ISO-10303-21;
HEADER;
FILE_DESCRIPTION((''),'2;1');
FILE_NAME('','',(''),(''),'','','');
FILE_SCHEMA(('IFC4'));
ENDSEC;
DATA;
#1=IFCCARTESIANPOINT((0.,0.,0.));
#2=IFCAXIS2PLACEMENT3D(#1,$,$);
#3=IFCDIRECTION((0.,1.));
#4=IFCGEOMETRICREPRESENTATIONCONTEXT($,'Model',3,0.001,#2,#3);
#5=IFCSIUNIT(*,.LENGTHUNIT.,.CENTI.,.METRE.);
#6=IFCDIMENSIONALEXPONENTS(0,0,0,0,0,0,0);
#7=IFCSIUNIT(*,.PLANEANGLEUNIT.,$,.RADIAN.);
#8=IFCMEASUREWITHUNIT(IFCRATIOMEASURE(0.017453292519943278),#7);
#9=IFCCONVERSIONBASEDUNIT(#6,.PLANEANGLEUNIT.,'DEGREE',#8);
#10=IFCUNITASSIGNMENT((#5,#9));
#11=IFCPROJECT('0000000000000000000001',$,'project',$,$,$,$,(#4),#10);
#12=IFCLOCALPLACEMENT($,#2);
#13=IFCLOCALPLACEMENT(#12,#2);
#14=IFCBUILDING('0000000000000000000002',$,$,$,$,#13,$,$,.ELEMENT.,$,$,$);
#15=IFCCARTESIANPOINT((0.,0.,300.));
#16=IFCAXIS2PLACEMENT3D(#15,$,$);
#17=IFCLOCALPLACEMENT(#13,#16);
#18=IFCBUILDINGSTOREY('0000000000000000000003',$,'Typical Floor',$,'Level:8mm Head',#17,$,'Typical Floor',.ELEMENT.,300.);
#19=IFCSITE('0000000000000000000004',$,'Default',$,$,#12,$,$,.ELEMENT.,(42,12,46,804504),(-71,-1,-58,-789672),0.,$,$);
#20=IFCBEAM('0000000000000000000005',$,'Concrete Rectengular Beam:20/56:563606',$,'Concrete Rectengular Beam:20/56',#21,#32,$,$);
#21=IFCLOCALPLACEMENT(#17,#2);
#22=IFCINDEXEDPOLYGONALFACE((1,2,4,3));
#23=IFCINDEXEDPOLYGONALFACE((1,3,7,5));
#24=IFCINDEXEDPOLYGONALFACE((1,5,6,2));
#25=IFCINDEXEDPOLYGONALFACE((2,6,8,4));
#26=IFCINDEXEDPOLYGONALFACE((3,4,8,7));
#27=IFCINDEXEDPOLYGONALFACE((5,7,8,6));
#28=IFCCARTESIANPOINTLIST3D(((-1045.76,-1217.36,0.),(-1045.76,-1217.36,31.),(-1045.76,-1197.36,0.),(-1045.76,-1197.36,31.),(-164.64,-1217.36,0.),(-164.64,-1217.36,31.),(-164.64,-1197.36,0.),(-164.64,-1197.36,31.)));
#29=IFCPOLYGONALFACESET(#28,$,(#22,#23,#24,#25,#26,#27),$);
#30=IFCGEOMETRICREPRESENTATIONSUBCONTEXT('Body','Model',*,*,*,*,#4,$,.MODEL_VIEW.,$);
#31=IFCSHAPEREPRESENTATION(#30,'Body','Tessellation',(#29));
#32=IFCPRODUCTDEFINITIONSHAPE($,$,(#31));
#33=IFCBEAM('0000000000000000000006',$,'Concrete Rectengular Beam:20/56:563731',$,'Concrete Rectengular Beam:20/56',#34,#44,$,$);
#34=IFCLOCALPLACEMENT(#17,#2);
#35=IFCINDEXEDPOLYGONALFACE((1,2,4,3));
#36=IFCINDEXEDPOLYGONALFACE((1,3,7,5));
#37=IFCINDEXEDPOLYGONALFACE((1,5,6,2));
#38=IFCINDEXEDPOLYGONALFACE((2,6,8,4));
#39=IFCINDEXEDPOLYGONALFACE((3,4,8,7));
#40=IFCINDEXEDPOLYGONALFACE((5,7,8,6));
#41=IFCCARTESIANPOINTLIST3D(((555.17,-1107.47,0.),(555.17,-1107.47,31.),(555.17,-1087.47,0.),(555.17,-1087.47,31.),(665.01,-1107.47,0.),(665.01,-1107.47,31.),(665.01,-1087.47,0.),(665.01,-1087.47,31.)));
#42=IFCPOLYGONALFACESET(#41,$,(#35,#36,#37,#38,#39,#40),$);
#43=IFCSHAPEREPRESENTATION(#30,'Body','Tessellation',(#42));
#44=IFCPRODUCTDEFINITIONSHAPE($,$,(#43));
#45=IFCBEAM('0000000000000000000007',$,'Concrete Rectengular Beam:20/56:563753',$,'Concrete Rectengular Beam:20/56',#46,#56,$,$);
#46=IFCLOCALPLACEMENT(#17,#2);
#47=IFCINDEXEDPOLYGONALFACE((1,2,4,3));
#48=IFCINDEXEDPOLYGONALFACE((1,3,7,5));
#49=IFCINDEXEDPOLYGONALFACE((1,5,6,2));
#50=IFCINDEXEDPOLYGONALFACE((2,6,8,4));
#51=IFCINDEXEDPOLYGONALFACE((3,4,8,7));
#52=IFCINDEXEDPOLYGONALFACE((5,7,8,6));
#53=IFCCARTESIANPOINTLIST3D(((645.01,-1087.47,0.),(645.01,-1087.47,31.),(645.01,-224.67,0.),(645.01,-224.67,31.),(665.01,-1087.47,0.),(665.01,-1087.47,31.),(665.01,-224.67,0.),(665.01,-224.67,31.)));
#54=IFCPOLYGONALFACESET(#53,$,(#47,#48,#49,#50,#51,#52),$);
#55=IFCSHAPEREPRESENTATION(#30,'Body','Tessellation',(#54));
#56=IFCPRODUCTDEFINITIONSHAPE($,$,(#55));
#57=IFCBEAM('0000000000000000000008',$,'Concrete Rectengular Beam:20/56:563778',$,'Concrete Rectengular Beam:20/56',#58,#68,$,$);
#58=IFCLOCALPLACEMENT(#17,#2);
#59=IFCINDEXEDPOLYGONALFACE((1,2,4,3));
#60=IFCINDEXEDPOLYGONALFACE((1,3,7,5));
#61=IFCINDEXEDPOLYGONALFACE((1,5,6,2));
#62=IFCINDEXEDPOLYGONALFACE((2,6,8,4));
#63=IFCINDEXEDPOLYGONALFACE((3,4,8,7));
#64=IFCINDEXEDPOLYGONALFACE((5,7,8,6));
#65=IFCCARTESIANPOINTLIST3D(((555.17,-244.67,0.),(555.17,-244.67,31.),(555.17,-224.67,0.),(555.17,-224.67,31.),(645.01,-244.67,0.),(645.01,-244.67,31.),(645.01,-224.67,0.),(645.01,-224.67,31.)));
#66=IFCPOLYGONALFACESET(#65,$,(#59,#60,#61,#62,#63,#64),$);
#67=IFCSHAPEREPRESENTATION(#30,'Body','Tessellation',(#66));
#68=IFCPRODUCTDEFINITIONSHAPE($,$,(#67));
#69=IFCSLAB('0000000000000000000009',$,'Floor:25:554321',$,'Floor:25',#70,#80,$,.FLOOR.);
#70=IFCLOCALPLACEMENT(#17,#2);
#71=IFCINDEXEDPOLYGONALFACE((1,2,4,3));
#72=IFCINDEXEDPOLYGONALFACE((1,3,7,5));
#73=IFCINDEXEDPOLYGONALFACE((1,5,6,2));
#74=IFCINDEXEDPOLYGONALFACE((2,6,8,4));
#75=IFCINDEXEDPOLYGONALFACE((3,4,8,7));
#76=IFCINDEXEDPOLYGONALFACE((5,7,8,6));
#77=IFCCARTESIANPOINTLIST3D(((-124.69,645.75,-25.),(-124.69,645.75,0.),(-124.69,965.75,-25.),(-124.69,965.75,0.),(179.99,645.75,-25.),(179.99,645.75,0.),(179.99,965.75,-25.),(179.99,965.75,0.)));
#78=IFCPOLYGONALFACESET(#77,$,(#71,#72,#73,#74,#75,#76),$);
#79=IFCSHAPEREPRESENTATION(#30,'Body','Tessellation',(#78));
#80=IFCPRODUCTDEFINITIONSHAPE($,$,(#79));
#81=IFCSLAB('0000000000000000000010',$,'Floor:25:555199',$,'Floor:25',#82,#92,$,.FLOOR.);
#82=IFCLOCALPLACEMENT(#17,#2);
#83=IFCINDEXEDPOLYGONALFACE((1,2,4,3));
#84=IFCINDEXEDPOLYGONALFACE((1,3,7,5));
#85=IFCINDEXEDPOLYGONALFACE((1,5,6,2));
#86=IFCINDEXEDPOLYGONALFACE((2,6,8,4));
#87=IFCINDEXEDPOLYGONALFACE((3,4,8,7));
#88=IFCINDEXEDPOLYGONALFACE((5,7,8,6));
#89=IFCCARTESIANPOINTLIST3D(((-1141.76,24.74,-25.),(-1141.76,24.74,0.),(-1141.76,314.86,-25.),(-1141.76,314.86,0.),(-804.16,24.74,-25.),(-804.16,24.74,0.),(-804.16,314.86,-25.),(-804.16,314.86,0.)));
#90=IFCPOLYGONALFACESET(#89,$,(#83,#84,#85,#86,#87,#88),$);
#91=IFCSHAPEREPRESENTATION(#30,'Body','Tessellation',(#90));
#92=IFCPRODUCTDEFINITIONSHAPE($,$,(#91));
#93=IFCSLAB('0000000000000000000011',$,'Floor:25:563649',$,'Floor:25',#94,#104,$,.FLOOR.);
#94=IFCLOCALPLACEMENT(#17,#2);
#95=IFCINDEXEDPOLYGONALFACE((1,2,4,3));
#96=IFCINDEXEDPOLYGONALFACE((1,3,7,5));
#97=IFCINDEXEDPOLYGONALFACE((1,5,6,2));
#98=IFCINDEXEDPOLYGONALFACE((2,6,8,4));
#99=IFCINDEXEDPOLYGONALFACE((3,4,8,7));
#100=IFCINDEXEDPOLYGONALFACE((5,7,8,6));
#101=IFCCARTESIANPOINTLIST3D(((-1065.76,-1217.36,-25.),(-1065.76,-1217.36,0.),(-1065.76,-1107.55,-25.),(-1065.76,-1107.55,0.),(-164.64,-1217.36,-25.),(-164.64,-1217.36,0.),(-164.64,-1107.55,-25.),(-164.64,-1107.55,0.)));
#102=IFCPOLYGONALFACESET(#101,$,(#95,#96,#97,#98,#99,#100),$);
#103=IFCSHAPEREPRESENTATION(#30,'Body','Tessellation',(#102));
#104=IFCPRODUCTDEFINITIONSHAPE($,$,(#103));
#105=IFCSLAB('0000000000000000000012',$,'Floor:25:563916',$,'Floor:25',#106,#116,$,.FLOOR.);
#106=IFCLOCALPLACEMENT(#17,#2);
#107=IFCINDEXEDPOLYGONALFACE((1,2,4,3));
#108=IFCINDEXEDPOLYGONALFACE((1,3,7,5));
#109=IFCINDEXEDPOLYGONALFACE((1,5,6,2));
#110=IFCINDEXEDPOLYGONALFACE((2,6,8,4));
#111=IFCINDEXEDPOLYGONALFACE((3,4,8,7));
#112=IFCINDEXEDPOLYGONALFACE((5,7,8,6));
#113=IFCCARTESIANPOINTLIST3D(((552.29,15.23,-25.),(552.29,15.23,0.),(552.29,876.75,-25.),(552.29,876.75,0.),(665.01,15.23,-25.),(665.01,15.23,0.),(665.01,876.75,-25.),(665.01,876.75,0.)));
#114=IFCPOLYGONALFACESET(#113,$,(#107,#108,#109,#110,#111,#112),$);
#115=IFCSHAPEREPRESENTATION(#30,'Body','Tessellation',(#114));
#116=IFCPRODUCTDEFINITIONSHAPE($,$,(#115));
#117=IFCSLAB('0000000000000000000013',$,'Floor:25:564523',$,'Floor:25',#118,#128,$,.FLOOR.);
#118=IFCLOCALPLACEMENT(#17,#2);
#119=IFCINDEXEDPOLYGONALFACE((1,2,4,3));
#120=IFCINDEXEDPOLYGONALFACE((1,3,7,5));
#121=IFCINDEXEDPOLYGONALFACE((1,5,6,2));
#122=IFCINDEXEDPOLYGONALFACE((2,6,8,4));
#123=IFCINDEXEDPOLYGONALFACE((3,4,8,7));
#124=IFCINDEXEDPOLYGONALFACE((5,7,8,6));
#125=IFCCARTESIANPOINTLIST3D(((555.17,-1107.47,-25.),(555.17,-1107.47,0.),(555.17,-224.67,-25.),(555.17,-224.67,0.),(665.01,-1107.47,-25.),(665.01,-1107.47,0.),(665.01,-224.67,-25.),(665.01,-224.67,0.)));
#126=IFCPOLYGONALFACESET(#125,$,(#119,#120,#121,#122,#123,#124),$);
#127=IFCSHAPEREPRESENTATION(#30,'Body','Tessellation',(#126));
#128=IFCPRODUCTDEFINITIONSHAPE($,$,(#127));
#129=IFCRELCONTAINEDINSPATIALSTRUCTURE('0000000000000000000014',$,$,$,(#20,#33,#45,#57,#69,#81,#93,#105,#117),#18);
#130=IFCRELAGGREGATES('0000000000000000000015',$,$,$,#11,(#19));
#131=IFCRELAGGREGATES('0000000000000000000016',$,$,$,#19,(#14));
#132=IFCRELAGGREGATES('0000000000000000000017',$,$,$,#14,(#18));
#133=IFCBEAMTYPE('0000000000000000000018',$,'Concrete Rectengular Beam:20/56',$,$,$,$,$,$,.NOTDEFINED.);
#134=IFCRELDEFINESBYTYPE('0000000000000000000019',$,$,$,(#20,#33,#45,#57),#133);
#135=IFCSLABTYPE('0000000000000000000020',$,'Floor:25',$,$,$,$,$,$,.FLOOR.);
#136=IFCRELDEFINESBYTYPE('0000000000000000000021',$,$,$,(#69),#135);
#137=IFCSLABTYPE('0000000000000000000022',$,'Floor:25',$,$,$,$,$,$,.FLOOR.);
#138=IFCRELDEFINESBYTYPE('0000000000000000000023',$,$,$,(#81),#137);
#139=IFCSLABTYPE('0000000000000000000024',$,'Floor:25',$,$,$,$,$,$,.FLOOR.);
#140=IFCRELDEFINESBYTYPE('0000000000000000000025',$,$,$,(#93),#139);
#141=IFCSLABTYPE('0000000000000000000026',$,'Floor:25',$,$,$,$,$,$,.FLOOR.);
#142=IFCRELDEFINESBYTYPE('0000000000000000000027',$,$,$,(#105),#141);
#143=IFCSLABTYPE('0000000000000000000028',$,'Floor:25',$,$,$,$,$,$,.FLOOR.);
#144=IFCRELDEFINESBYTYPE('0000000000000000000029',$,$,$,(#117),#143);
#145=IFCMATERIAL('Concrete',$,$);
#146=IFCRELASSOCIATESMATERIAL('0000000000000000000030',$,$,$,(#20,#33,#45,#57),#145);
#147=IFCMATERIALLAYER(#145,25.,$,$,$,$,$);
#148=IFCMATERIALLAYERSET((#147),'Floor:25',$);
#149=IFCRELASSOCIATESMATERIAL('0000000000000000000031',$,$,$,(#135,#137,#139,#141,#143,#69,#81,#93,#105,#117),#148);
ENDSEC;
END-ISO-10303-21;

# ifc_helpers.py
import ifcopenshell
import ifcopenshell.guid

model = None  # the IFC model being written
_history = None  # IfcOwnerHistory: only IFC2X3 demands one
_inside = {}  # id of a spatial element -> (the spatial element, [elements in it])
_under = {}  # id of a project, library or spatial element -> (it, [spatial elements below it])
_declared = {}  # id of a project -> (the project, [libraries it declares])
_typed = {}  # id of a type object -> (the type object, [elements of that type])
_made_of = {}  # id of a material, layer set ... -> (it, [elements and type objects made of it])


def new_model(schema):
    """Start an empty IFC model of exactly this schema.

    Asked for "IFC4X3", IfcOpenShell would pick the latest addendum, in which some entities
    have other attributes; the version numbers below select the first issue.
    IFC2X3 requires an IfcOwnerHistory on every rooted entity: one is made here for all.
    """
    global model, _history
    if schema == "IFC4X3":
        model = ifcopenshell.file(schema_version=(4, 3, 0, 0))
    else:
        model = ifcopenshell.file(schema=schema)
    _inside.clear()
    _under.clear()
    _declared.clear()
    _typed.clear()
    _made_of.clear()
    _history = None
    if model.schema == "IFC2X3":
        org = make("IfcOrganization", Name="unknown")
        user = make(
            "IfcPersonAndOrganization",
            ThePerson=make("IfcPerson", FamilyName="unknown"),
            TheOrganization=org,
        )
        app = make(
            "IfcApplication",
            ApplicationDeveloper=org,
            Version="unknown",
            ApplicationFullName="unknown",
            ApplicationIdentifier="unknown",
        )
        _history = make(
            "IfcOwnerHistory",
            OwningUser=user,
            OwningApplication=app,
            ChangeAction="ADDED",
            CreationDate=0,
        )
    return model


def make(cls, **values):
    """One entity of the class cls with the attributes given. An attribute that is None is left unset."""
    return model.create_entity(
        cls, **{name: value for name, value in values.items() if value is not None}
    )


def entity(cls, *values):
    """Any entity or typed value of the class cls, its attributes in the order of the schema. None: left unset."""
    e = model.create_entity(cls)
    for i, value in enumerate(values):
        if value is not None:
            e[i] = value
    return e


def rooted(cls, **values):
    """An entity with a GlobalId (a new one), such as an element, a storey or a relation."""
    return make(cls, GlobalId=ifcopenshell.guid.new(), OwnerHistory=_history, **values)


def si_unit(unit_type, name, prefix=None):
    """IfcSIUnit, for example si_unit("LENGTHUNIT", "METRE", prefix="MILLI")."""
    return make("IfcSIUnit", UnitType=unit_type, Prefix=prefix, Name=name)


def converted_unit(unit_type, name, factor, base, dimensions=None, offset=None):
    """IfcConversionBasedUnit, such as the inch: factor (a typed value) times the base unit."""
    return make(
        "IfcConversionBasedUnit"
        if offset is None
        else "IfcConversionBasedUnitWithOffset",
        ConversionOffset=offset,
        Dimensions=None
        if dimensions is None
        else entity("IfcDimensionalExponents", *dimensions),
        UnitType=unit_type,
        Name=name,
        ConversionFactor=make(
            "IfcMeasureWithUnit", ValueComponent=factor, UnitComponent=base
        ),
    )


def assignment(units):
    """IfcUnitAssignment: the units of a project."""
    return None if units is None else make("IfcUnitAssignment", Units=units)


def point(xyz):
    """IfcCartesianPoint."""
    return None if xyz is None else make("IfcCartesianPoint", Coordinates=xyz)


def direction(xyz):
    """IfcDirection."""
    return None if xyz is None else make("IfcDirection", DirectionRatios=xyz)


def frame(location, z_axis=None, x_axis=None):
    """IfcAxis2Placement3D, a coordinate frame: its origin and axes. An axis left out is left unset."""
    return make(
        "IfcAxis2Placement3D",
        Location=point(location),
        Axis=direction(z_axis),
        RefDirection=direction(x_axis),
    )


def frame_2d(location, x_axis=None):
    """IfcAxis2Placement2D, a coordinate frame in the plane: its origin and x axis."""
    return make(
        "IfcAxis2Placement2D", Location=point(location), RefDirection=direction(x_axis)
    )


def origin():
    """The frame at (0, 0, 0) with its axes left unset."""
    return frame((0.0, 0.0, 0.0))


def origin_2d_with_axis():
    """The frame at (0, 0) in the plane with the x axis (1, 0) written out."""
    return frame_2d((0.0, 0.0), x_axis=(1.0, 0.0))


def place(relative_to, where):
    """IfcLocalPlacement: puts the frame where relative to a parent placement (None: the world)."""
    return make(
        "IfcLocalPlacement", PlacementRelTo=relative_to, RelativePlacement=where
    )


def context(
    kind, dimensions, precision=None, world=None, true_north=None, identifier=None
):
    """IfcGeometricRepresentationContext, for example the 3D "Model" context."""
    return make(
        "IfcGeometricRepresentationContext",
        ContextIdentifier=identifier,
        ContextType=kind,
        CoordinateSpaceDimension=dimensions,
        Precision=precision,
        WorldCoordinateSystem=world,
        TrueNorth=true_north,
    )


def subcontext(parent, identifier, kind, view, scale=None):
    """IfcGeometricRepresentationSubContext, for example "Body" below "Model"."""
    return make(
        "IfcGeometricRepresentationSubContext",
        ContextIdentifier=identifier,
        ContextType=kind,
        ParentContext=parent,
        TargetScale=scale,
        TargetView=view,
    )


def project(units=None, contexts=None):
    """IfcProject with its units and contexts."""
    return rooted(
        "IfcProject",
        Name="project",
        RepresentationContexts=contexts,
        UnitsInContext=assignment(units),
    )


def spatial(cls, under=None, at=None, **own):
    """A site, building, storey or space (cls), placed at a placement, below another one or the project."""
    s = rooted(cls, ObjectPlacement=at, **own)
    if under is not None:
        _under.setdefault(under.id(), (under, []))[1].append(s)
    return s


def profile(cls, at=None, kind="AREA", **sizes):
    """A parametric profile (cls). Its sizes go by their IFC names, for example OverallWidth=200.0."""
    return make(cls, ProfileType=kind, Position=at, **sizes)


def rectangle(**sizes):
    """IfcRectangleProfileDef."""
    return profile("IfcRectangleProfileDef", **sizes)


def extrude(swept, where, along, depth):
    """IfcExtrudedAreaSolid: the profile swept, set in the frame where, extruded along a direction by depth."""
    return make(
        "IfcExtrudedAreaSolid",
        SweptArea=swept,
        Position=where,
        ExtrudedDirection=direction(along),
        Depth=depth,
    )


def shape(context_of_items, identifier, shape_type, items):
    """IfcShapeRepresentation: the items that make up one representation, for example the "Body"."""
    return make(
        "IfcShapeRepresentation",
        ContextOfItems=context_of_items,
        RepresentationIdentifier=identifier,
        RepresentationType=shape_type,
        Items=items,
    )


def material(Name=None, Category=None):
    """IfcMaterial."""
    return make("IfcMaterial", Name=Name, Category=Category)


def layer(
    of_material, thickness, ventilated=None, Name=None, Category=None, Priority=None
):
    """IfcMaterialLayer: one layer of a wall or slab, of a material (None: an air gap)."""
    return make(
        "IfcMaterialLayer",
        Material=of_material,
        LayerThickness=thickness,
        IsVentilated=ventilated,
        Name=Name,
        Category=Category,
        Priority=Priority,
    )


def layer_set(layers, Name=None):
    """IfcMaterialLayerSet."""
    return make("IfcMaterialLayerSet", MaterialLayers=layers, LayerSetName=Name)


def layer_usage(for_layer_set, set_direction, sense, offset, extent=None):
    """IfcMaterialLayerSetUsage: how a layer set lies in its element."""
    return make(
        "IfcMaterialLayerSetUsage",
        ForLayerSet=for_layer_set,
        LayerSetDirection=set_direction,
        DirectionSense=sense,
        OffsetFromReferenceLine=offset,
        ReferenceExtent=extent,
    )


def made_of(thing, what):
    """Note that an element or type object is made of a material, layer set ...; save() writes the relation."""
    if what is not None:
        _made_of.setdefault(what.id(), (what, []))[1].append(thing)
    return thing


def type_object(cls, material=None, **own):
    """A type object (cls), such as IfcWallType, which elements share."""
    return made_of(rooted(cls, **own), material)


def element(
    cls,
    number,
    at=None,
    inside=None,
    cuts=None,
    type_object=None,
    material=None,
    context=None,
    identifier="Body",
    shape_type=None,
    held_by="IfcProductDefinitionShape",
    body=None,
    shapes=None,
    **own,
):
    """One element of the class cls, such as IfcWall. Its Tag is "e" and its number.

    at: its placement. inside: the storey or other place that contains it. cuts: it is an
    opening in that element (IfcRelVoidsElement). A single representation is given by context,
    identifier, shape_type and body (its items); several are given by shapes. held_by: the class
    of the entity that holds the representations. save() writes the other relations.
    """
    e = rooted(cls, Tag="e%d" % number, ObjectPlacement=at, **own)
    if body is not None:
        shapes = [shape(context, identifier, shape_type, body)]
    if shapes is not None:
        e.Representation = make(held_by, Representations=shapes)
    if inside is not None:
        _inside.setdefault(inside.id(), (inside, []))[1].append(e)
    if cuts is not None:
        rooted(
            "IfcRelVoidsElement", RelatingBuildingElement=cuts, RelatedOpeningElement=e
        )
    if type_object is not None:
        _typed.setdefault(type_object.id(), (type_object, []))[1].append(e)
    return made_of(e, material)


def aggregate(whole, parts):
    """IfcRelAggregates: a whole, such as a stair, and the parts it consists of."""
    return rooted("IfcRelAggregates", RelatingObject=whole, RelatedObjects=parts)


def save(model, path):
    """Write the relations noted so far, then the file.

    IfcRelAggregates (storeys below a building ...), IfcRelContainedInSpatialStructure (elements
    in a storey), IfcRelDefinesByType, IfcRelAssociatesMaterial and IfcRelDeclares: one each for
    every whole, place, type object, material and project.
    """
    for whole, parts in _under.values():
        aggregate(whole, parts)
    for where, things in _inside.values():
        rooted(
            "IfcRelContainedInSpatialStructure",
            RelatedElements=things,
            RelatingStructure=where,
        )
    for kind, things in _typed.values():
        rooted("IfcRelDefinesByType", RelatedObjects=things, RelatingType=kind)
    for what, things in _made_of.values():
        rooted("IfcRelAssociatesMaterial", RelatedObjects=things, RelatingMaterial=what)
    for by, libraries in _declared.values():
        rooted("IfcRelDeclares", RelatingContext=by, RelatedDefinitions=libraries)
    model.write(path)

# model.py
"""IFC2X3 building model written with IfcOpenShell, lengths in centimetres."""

from ifc_helpers import new_model, entity, si_unit, converted_unit, direction, frame, frame_2d, origin, origin_2d_with_axis, place, context, subcontext, project, spatial, rectangle, extrude, material, layer, layer_set, layer_usage, type_object, element, save


model = new_model("IFC2X3")

# Units and contexts
model_context = context("Model", 3, precision=0.001, world=origin(), true_north=direction((0.0, 1.0)))
body_context = subcontext(model_context, "Body", "Model", "MODEL_VIEW")
ifc_project = project(units=[si_unit("LENGTHUNIT", "METRE", prefix="CENTI"), converted_unit("PLANEANGLEUNIT", "DEGREE", entity("IfcRatioMeasure", 0.017453292519943278), si_unit("PLANEANGLEUNIT", "RADIAN"), dimensions=[0, 0, 0, 0, 0, 0, 0])], contexts=[model_context])

# Site, building, storey
site_placement = place(None, origin())
site = spatial("IfcSite", under=ifc_project, at=site_placement, Name="Default", CompositionType="ELEMENT", RefLatitude=(42, 12, 46, 804504), RefLongitude=(-71, -1, -58, -789672), RefElevation=0.0)
building_placement = place(site_placement, origin())
building = spatial("IfcBuilding", under=site, at=building_placement, CompositionType="ELEMENT")
storey_placement = place(building_placement, frame((0.0, 0.0, 300.0)))
storey = spatial("IfcBuildingStorey", under=building, at=storey_placement, Name="Typical Floor", ObjectType="Level:8mm Head", LongName="Typical Floor", CompositionType="ELEMENT", Elevation=300.0)

# Beams
ifc_material = material(Name="Concrete")
beam_type_1 = type_object("IfcBeamType", Name="Concrete Rectengular Beam:20/56", PredefinedType="NOTDEFINED")
beam_1_placement = place(storey_placement, frame((-1055.76, -1207.36, 0.0)))
element("IfcBeam", 1, at=beam_1_placement, inside=storey, type_object=beam_type_1, material=ifc_material, Name="Concrete Rectengular Beam:20/56:563606", ObjectType="Concrete Rectengular Beam:20/56", context=body_context, shape_type="SweptSolid", body=[
    extrude(rectangle(XDim=31.0, YDim=20.0, at=frame_2d((0.0, 0.0), x_axis=(1.0, 0.0))), frame((10.0, 0.0, 15.5), z_axis=(1.0, 0.0, 0.0), x_axis=(0.0, 0.0, -1.0)), (0.0, 0.0, 1.0), 881.12),
])
beam_2_placement = place(storey_placement, frame((555.17, -1097.47, 0.0)))
element("IfcBeam", 2, at=beam_2_placement, inside=storey, type_object=beam_type_1, material=ifc_material, Name="Concrete Rectengular Beam:20/56:563731", ObjectType="Concrete Rectengular Beam:20/56", context=body_context, shape_type="SweptSolid", body=[
    extrude(rectangle(XDim=31.0, YDim=20.0, at=frame_2d((0.0, 0.0), x_axis=(1.0, 0.0))), frame((0.0, 0.0, 15.5), z_axis=(1.0, 0.0, 0.0), x_axis=(0.0, 0.0, -1.0)), (0.0, 0.0, 1.0), 109.84),
])
beam_3_placement = place(storey_placement, frame((655.01, -1097.47, 0.0), z_axis=(0.0, 0.0, 1.0), x_axis=(0.0, 1.0, 0.0)))
element("IfcBeam", 3, at=beam_3_placement, inside=storey, type_object=beam_type_1, material=ifc_material, Name="Concrete Rectengular Beam:20/56:563753", ObjectType="Concrete Rectengular Beam:20/56", context=body_context, shape_type="SweptSolid", body=[
    extrude(rectangle(XDim=31.0, YDim=20.0, at=frame_2d((0.0, 0.0), x_axis=(1.0, 0.0))), frame((10.0, 0.0, 15.5), z_axis=(1.0, 0.0, 0.0), x_axis=(0.0, 0.0, -1.0)), (0.0, 0.0, 1.0), 862.8),
])
beam_4_placement = place(storey_placement, frame((655.01, -234.67, 0.0), z_axis=(0.0, 0.0, 1.0), x_axis=(-1.0, 0.0, 0.0)))
element("IfcBeam", 4, at=beam_4_placement, inside=storey, type_object=beam_type_1, material=ifc_material, Name="Concrete Rectengular Beam:20/56:563778", ObjectType="Concrete Rectengular Beam:20/56", context=body_context, shape_type="SweptSolid", body=[
    extrude(rectangle(XDim=31.0, YDim=20.0, at=frame_2d((0.0, 0.0), x_axis=(1.0, 0.0))), frame((10.0, 0.0, 15.5), z_axis=(1.0, 0.0, 0.0), x_axis=(0.0, 0.0, -1.0)), (0.0, 0.0, 1.0), 89.84),
])

# Slabs
ifc_layer = layer(ifc_material, 25.0)
ifc_layer_set = layer_set([ifc_layer], Name="Floor:25")
ifc_layer_usage_1 = layer_usage(ifc_layer_set, "AXIS3", "POSITIVE", 0.0)
slab_type_1 = type_object("IfcSlabType", Name="Floor:25", PredefinedType="FLOOR", material=ifc_layer_set)
slab_1_placement = place(storey_placement, origin())
element("IfcSlab", 5, at=slab_1_placement, inside=storey, type_object=slab_type_1, material=ifc_layer_usage_1, Name="Floor:25:554321", ObjectType="Floor:25", PredefinedType="FLOOR", context=body_context, shape_type="SweptSolid", body=[
    extrude(rectangle(XDim=320.0, YDim=304.68, at=frame_2d((0.0, 0.0), x_axis=(1.0, 0.0))), frame((27.65, 805.75, 0.0), z_axis=(0.0, 0.0, -1.0), x_axis=(0.0, 1.0, 0.0)), (0.0, 0.0, 1.0), 25.0),
])
ifc_layer_usage_2 = layer_usage(ifc_layer_set, "AXIS3", "POSITIVE", 0.0)
slab_type_2 = type_object("IfcSlabType", Name="Floor:25", PredefinedType="FLOOR", material=ifc_layer_set)
slab_2_placement = place(storey_placement, origin())
element("IfcSlab", 6, at=slab_2_placement, inside=storey, type_object=slab_type_2, material=ifc_layer_usage_2, Name="Floor:25:555199", ObjectType="Floor:25", PredefinedType="FLOOR", context=body_context, shape_type="SweptSolid", body=[
    extrude(rectangle(XDim=290.12, YDim=337.6, at=origin_2d_with_axis()), frame((-972.96, 169.8, 0.0), z_axis=(0.0, 0.0, -1.0), x_axis=(0.0, 1.0, 0.0)), (0.0, 0.0, 1.0), 25.0),
])
ifc_layer_usage_3 = layer_usage(ifc_layer_set, "AXIS3", "POSITIVE", 0.0)
slab_type_3 = type_object("IfcSlabType", Name="Floor:25", PredefinedType="FLOOR", material=ifc_layer_set)
slab_3_placement = place(storey_placement, origin())
element("IfcSlab", 7, at=slab_3_placement, inside=storey, type_object=slab_type_3, material=ifc_layer_usage_3, Name="Floor:25:563649", ObjectType="Floor:25", PredefinedType="FLOOR", context=body_context, shape_type="SweptSolid", body=[
    extrude(rectangle(XDim=109.81, YDim=901.12, at=frame_2d((0.0, 0.0), x_axis=(1.0, 0.0))), frame((-615.2, -1162.46, 0.0), z_axis=(0.0, 0.0, -1.0), x_axis=(0.0, 1.0, 0.0)), (0.0, 0.0, 1.0), 25.0),
])
ifc_layer_usage_4 = layer_usage(ifc_layer_set, "AXIS3", "POSITIVE", 0.0)
slab_type_4 = type_object("IfcSlabType", Name="Floor:25", PredefinedType="FLOOR", material=ifc_layer_set)
slab_4_placement = place(storey_placement, origin())
element("IfcSlab", 8, at=slab_4_placement, inside=storey, type_object=slab_type_4, material=ifc_layer_usage_4, Name="Floor:25:563916", ObjectType="Floor:25", PredefinedType="FLOOR", context=body_context, shape_type="SweptSolid", body=[
    extrude(rectangle(XDim=861.51, YDim=112.73, at=frame_2d((0.0, 0.0), x_axis=(1.0, 0.0))), frame((608.65, 445.99, 0.0), z_axis=(0.0, 0.0, -1.0), x_axis=(0.0, 1.0, 0.0)), (0.0, 0.0, 1.0), 25.0),
])
ifc_layer_usage_5 = layer_usage(ifc_layer_set, "AXIS3", "POSITIVE", 0.0)
slab_type_5 = type_object("IfcSlabType", Name="Floor:25", PredefinedType="FLOOR", material=ifc_layer_set)
slab_5_placement = place(storey_placement, origin())
element("IfcSlab", 9, at=slab_5_placement, inside=storey, type_object=slab_type_5, material=ifc_layer_usage_5, Name="Floor:25:564523", ObjectType="Floor:25", PredefinedType="FLOOR", context=body_context, shape_type="SweptSolid", body=[
    extrude(rectangle(XDim=882.8, YDim=109.84, at=frame_2d((0.0, 0.0), x_axis=(1.0, 0.0))), frame((610.09, -666.07, 0.0), z_axis=(0.0, 0.0, -1.0), x_axis=(0.0, 1.0, 0.0)), (0.0, 0.0, 1.0), 25.0),
])

save(model, "model.ifc")
